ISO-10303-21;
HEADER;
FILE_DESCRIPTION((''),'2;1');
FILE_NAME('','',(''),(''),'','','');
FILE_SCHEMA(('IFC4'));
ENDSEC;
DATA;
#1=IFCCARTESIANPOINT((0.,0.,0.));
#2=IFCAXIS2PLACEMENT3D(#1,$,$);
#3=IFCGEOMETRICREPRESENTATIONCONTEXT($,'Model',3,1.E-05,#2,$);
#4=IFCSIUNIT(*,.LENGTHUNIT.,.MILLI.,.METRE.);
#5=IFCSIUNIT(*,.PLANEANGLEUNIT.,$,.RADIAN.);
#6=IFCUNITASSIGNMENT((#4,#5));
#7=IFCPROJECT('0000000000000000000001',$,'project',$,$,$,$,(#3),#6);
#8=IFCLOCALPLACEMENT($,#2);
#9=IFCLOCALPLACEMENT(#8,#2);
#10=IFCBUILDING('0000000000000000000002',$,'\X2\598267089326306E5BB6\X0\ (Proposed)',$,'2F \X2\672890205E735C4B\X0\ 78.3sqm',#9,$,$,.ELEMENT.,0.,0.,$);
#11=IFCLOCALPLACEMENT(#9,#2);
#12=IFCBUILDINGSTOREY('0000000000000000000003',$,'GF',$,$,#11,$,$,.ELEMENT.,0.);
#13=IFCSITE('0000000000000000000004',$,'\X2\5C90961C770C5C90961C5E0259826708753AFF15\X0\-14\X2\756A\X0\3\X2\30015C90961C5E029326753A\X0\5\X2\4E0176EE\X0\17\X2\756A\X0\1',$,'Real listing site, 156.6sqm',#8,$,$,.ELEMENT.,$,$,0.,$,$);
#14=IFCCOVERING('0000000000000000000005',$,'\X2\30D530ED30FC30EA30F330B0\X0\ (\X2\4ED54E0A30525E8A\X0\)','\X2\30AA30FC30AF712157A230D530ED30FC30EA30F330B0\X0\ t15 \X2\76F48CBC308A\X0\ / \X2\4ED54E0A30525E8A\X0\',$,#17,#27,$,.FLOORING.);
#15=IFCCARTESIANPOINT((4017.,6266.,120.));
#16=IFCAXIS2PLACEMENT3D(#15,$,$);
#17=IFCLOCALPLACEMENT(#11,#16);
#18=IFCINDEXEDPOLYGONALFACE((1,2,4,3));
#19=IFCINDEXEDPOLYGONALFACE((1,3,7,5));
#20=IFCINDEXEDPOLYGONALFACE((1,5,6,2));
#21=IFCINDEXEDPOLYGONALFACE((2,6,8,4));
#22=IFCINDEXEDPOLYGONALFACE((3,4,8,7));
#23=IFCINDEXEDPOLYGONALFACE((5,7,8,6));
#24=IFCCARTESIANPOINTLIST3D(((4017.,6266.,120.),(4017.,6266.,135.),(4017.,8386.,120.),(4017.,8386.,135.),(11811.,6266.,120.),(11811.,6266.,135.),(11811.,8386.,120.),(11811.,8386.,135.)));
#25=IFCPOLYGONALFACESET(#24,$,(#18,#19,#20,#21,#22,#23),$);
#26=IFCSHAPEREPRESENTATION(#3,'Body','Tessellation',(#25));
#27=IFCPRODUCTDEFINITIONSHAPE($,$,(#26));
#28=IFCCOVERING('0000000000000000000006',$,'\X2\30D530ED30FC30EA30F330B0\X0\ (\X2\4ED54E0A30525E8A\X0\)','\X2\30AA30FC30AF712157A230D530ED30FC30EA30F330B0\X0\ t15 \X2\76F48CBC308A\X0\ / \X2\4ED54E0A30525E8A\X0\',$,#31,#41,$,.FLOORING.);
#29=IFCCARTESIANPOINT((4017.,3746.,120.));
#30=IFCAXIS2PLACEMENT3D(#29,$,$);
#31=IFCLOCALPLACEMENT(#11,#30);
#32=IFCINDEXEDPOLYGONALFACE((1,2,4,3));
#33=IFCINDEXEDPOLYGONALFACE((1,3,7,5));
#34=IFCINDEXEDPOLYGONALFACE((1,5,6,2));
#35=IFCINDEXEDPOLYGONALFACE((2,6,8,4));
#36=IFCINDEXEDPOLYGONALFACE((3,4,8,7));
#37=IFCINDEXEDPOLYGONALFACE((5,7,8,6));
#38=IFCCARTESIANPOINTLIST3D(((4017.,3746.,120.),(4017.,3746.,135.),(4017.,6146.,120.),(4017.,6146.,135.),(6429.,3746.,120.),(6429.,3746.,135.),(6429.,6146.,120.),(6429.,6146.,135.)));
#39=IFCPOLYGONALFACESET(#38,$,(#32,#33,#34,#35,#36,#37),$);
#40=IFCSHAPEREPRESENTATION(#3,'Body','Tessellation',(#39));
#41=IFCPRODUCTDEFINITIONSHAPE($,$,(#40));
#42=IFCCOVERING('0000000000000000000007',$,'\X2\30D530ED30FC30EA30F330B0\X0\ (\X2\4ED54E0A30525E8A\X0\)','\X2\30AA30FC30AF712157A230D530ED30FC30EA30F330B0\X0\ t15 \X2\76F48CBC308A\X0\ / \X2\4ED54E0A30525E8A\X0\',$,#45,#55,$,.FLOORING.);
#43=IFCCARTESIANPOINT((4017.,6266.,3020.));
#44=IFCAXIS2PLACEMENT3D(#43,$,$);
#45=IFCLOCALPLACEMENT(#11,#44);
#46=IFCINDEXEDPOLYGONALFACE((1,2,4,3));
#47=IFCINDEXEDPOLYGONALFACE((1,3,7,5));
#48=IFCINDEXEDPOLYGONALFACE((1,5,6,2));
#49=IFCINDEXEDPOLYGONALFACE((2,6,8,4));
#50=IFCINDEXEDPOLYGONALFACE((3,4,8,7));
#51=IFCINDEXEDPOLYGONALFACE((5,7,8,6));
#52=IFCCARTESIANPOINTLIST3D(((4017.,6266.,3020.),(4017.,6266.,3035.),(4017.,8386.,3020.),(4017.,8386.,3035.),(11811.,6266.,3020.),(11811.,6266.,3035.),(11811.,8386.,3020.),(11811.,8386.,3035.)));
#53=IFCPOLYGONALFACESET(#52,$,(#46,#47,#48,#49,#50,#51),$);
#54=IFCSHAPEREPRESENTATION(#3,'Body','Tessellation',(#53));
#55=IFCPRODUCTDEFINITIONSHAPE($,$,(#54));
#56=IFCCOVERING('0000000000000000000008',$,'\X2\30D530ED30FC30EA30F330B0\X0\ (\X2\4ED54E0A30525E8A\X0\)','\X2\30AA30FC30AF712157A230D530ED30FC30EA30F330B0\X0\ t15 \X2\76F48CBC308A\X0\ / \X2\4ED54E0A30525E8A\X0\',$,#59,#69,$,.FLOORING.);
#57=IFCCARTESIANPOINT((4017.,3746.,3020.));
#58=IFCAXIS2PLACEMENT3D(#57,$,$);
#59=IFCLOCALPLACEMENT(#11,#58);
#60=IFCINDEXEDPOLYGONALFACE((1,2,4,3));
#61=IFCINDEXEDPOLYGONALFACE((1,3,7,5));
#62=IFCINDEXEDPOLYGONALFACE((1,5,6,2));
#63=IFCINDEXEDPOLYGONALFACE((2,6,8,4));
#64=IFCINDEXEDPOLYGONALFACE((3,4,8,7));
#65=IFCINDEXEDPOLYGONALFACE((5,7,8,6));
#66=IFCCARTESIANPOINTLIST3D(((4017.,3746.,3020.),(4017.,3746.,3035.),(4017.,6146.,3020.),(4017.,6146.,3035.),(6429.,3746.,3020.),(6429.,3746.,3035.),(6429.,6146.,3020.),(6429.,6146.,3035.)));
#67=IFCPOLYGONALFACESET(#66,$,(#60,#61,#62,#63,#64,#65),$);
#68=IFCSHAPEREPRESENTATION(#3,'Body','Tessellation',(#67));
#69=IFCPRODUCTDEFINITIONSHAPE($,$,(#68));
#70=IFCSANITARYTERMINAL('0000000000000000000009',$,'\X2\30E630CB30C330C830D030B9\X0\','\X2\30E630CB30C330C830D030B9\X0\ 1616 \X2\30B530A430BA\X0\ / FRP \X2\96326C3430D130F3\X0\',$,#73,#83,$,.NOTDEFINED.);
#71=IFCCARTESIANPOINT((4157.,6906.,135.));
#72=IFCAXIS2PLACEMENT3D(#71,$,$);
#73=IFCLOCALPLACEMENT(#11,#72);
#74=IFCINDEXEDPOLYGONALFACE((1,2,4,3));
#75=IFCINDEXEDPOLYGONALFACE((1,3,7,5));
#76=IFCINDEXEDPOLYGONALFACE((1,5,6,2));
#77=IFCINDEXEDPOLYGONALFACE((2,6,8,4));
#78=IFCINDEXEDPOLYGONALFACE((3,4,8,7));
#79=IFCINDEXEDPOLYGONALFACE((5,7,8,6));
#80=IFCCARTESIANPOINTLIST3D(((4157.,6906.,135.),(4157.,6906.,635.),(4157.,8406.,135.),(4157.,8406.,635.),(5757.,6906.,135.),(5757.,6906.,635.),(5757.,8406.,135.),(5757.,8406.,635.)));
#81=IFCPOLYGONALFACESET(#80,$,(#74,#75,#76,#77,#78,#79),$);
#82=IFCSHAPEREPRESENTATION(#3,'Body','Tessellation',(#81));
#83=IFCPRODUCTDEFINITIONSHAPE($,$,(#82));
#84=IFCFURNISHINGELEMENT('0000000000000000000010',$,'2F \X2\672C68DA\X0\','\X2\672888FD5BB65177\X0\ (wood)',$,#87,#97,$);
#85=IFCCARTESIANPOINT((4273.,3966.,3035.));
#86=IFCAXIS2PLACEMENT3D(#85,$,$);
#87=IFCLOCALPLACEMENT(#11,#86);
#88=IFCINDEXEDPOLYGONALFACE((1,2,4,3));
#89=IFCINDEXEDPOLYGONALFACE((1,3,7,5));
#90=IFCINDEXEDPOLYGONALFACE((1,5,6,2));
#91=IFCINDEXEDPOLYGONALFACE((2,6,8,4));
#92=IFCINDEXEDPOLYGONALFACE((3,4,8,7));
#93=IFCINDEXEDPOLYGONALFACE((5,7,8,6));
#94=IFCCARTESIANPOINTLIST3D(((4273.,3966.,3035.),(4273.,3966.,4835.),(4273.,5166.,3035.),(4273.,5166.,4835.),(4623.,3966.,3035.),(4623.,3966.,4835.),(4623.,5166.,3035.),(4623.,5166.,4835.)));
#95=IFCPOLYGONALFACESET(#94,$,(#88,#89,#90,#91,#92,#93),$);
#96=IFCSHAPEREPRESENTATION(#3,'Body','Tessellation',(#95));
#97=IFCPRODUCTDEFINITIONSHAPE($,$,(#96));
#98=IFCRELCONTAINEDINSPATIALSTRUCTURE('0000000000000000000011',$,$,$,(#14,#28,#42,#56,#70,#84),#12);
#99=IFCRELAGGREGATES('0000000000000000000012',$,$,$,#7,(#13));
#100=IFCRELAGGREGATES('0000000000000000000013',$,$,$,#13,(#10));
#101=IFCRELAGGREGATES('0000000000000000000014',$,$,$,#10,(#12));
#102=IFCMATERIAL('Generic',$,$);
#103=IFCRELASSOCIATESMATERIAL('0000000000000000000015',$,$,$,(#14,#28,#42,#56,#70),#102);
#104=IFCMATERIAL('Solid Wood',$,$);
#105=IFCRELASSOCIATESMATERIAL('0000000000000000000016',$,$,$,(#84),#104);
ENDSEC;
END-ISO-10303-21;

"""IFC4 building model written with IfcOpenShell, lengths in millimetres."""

from ifc_helpers import new_model, si_unit, frame, frame_2d, origin, place, context, project, spatial, rectangle, extrude, material, element, save


model = new_model("IFC4")

# Units and contexts
model_context = context("Model", 3, precision=1e-05, world=origin())
ifc_project = project(units=[si_unit("LENGTHUNIT", "METRE", prefix="MILLI"), si_unit("PLANEANGLEUNIT", "RADIAN")], contexts=[model_context])

# Site, building, storey
site_placement = place(None, origin())
site = spatial("IfcSite", under=ifc_project, at=site_placement, Name="岐阜県岐阜市如月町５-14番3、岐阜市錦町5丁目17番1", ObjectType="Real listing site, 156.6sqm", CompositionType="ELEMENT", RefElevation=0.0)
building_placement = place(site_placement, origin())
building = spatial("IfcBuilding", under=site, at=building_placement, Name="如月錦の家 (Proposed)", ObjectType="2F 木造平屋 78.3sqm", CompositionType="ELEMENT", ElevationOfRefHeight=0.0, ElevationOfTerrain=0.0)
storey_placement = place(building_placement, origin())
storey = spatial("IfcBuildingStorey", under=building, at=storey_placement, Name="GF", CompositionType="ELEMENT", Elevation=0.0)

# Shared definitions
ifc_material_1 = material(Name="Solid Wood")

# Coverings
ifc_material_2 = material(Name="Generic")
covering_1_placement = place(storey_placement, frame((4017.0, 6266.0, 120.0)))
element("IfcCovering", 1, at=covering_1_placement, inside=storey, material=ifc_material_2, Name="フローリング (仕上げ床)", Description="オーク無垢フローリング t15 直貼り / 仕上げ床", PredefinedType="FLOORING", context=model_context, shape_type="SweptSolid", body=[
    extrude(rectangle(XDim=7794.0, YDim=2120.0, at=frame_2d((3897.0, 1060.0))), frame((4017.0, 6266.0, 120.0)), (0.0, 0.0, 1.0), 15.0),
])
covering_2_placement = place(storey_placement, frame((4017.0, 3746.0, 120.0)))
element("IfcCovering", 2, at=covering_2_placement, inside=storey, material=ifc_material_2, Name="フローリング (仕上げ床)", Description="オーク無垢フローリング t15 直貼り / 仕上げ床", PredefinedType="FLOORING", context=model_context, shape_type="SweptSolid", body=[
    extrude(rectangle(XDim=2412.0, YDim=2400.0, at=frame_2d((1206.0, 1200.0))), frame((4017.0, 3746.0, 120.0)), (0.0, 0.0, 1.0), 15.0),
])
covering_3_placement = place(storey_placement, frame((4017.0, 6266.0, 3020.0)))
element("IfcCovering", 3, at=covering_3_placement, inside=storey, material=ifc_material_2, Name="フローリング (仕上げ床)", Description="オーク無垢フローリング t15 直貼り / 仕上げ床", PredefinedType="FLOORING", context=model_context, shape_type="SweptSolid", body=[
    extrude(rectangle(XDim=7794.0, YDim=2120.0, at=frame_2d((3897.0, 1060.0))), frame((4017.0, 6266.0, 3020.0)), (0.0, 0.0, 1.0), 15.0),
])
covering_4_placement = place(storey_placement, frame((4017.0, 3746.0, 3020.0)))
element("IfcCovering", 4, at=covering_4_placement, inside=storey, material=ifc_material_2, Name="フローリング (仕上げ床)", Description="オーク無垢フローリング t15 直貼り / 仕上げ床", PredefinedType="FLOORING", context=model_context, shape_type="SweptSolid", body=[
    extrude(rectangle(XDim=2412.0, YDim=2400.0, at=frame_2d((1206.0, 1200.0))), frame((4017.0, 3746.0, 3020.0)), (0.0, 0.0, 1.0), 15.0),
])

# Sanitary terminal
sanitary_terminal_placement = place(storey_placement, frame((4157.0, 6906.0, 135.0)))
element("IfcSanitaryTerminal", 5, at=sanitary_terminal_placement, inside=storey, material=ifc_material_2, Name="ユニットバス", Description="ユニットバス 1616 サイズ / FRP 防水パン", PredefinedType="NOTDEFINED", context=model_context, shape_type="SweptSolid", body=[
    extrude(rectangle(XDim=1600.0, YDim=1500.0, at=frame_2d((800.0, 750.0))), frame((4157.0, 6906.0, 135.0)), (0.0, 0.0, 1.0), 500.0),
])

# Furnishing element
furnishing_placement = place(storey_placement, frame((4273.0, 3966.0, 3035.0)))
element("IfcFurnishingElement", 6, at=furnishing_placement, inside=storey, material=ifc_material_1, Name="2F 本棚", Description="木製家具 (wood)", context=model_context, shape_type="SweptSolid", body=[
    extrude(rectangle(XDim=350.0, YDim=1200.0, at=frame_2d((175.0, 600.0))), frame((4273.0, 3966.0, 3035.0)), (0.0, 0.0, 1.0), 1800.0),
])

save(model, "model.ifc")
